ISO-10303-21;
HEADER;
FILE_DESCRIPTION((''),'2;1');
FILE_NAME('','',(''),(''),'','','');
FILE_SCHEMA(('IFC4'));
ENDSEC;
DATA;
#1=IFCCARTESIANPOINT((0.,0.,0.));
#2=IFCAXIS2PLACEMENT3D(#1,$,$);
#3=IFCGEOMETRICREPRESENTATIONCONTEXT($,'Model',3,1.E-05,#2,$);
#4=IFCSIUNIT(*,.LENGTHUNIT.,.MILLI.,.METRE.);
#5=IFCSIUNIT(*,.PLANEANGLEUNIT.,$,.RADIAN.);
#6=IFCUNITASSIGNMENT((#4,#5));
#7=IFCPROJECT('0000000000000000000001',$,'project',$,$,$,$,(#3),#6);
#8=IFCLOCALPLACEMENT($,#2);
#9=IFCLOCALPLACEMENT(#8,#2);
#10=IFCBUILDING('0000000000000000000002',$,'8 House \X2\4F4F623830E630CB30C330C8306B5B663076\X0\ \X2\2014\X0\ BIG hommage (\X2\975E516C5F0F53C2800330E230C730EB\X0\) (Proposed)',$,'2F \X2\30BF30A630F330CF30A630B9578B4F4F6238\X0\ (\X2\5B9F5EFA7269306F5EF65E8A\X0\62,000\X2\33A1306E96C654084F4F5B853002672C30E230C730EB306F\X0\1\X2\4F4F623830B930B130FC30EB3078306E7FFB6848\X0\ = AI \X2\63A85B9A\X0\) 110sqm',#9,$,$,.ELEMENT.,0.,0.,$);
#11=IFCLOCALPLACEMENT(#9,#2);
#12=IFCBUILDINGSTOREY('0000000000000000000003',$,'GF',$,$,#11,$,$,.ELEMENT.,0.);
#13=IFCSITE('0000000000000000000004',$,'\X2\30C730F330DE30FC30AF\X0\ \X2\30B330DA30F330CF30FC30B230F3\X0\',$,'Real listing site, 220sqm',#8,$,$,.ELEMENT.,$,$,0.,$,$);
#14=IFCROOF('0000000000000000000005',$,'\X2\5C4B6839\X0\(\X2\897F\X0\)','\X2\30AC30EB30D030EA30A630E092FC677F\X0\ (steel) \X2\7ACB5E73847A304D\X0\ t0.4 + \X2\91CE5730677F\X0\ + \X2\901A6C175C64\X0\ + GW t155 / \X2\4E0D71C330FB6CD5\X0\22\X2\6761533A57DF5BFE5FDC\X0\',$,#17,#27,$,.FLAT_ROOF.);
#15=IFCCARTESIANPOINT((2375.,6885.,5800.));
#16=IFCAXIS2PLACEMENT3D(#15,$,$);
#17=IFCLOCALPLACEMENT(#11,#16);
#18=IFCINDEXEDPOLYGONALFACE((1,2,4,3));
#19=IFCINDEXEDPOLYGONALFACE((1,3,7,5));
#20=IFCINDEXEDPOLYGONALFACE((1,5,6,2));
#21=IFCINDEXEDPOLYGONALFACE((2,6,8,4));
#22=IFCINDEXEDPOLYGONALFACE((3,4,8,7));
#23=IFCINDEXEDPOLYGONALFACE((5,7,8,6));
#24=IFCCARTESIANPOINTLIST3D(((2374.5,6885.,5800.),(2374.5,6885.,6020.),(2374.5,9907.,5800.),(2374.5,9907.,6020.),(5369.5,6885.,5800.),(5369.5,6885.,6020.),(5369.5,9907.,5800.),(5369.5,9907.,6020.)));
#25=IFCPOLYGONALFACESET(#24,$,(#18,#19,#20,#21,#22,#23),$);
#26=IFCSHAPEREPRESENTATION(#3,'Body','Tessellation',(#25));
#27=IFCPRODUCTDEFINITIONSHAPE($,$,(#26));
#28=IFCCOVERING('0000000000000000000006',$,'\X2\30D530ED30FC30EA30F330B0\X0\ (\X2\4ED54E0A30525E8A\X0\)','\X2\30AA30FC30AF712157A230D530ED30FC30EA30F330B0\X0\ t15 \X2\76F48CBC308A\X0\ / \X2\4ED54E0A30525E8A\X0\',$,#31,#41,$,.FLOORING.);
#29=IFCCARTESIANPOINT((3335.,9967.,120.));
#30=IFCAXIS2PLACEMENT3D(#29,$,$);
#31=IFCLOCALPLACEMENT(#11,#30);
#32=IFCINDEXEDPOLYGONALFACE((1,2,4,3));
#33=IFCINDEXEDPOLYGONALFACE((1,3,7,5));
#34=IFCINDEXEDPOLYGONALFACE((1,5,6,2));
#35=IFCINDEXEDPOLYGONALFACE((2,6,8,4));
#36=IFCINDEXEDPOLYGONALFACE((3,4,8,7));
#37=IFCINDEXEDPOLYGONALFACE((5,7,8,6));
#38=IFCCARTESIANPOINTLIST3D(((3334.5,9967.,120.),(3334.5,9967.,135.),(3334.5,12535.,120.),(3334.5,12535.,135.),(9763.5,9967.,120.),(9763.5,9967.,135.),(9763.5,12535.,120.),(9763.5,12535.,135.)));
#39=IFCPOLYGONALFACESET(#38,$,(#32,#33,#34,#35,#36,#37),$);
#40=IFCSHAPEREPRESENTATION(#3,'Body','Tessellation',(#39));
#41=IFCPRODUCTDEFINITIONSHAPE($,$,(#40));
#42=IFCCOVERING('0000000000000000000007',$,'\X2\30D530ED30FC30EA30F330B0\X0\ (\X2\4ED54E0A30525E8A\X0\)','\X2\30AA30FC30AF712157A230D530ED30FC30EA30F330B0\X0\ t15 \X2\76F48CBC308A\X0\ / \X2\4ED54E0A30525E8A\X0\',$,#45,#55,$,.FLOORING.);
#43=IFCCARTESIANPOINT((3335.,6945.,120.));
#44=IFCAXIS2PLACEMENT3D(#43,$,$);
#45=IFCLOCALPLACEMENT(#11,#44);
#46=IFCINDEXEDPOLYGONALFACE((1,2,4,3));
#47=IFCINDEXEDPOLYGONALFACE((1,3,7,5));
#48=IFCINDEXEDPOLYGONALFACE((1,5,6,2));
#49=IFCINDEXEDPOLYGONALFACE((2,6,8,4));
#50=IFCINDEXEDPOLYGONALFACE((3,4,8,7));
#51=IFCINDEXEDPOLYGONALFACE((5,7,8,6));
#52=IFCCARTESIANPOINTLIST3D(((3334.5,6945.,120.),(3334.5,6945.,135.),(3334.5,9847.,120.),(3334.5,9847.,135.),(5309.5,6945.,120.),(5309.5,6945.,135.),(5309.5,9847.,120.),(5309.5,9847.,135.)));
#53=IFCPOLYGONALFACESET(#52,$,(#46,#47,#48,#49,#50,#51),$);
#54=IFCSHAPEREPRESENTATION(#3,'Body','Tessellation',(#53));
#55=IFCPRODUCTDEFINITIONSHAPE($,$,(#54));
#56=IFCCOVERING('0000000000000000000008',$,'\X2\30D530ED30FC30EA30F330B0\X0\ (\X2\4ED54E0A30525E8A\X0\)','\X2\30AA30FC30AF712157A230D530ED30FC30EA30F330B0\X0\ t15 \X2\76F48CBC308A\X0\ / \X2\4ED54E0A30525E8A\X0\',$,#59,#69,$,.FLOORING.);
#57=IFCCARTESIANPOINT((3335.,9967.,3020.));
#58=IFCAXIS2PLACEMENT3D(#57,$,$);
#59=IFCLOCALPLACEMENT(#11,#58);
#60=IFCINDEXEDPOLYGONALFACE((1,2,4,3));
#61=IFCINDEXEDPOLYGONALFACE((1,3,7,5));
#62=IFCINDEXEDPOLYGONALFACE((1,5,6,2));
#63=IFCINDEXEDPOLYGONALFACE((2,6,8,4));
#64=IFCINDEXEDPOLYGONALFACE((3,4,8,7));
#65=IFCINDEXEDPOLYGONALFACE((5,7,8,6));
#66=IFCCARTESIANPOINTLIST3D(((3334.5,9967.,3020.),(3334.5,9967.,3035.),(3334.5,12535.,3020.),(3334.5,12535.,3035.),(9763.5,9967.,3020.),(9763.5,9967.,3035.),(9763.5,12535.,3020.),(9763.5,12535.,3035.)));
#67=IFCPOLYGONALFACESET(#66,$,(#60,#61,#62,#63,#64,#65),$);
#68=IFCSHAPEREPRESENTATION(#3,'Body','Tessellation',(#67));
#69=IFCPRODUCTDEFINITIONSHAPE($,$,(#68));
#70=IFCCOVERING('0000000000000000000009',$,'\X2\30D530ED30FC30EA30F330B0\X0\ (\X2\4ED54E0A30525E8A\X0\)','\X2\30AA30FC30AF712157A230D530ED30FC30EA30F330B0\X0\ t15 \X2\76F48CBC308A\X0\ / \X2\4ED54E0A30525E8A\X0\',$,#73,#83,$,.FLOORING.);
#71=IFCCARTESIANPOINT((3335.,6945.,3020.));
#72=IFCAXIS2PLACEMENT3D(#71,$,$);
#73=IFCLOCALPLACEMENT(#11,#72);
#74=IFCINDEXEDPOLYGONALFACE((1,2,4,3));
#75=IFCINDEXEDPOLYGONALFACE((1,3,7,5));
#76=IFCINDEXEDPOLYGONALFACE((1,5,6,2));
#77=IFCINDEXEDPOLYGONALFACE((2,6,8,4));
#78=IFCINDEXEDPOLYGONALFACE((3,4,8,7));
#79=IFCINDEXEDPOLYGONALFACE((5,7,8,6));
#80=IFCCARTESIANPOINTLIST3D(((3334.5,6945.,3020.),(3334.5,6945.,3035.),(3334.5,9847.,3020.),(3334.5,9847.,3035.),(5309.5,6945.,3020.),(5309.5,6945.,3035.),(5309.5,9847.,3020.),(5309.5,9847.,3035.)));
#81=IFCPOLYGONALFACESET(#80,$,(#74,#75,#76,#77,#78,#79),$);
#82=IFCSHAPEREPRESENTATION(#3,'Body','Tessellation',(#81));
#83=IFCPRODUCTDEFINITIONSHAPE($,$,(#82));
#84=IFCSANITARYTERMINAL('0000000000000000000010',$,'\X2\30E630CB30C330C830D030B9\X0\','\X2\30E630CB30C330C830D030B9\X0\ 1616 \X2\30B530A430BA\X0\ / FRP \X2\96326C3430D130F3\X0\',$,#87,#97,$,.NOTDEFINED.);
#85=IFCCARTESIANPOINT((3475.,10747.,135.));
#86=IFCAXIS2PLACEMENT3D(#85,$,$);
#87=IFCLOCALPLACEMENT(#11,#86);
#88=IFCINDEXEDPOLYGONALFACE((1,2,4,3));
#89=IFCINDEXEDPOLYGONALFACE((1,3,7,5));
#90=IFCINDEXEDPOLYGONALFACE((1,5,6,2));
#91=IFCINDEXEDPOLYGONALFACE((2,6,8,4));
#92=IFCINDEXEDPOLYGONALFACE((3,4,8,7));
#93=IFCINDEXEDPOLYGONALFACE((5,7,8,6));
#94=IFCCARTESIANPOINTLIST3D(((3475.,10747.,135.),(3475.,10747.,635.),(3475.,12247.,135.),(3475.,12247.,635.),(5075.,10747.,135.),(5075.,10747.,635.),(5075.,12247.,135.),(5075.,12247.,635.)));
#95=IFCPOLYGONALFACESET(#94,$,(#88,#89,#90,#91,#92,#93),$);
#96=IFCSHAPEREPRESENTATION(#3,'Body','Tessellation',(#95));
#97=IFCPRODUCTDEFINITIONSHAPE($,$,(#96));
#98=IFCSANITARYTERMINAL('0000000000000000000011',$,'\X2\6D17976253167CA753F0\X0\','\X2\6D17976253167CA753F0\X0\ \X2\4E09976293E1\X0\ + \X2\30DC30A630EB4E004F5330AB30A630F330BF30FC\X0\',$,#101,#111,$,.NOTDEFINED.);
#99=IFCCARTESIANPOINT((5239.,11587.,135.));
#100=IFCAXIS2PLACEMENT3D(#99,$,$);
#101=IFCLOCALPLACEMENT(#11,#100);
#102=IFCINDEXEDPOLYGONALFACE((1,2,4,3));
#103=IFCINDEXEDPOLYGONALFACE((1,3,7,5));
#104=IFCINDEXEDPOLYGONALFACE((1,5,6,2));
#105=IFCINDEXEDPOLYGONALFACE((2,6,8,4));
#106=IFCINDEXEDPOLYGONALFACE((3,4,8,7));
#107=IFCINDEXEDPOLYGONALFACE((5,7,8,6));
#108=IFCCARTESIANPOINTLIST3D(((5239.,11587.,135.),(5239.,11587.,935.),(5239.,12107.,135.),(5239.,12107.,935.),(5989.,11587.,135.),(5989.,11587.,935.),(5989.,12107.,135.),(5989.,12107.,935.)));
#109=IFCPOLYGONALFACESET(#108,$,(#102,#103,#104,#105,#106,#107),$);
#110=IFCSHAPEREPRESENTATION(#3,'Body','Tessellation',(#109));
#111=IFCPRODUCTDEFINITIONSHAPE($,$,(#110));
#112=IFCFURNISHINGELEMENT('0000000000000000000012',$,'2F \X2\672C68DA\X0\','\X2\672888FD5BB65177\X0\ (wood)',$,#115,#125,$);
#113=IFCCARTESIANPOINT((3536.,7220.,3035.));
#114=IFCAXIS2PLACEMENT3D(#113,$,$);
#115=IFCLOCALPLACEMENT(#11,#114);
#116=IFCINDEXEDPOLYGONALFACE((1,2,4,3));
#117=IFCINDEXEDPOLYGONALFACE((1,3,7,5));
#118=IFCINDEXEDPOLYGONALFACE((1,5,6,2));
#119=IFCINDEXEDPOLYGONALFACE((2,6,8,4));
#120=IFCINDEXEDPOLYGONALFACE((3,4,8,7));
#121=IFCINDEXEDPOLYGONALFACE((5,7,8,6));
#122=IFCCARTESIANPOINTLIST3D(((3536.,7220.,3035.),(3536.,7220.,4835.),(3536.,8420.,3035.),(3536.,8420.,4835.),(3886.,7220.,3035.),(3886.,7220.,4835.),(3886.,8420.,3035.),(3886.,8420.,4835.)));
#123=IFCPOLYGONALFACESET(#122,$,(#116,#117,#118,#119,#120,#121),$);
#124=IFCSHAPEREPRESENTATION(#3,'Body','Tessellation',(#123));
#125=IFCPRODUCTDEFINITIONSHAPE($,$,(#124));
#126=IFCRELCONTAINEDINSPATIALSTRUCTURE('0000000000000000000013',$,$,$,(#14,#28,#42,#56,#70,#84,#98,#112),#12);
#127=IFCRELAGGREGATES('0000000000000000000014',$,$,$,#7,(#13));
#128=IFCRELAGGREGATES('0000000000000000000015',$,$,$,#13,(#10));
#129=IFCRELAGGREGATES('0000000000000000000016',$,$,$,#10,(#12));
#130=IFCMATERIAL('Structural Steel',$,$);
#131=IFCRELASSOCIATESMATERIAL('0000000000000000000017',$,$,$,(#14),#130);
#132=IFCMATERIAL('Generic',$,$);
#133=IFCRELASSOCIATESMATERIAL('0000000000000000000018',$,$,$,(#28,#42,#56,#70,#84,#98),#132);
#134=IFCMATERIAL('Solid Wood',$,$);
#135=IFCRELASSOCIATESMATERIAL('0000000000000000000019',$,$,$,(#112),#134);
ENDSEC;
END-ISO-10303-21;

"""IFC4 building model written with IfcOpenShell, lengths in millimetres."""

from ifc_helpers import new_model, si_unit, frame, frame_2d, origin, place, context, project, spatial, rectangle, extrude, material, element, save


model = new_model("IFC4")

# Units and contexts
model_context = context("Model", 3, precision=1e-05, world=origin())
ifc_project = project(units=[si_unit("LENGTHUNIT", "METRE", prefix="MILLI"), si_unit("PLANEANGLEUNIT", "RADIAN")], contexts=[model_context])

# Site, building, storey
site_placement = place(None, origin())
site = spatial("IfcSite", under=ifc_project, at=site_placement, Name="デンマーク コペンハーゲン", ObjectType="Real listing site, 220sqm", CompositionType="ELEMENT", RefElevation=0.0)
building_placement = place(site_placement, origin())
building = spatial("IfcBuilding", under=site, at=building_placement, Name="8 House 住戸ユニットに学ぶ — BIG hommage (非公式参考モデル) (Proposed)", ObjectType="2F タウンハウス型住戸 (実建物は延床62,000㎡の集合住宅。本モデルは1住戸スケールへの翻案 = AI 推定) 110sqm", CompositionType="ELEMENT", ElevationOfRefHeight=0.0, ElevationOfTerrain=0.0)
storey_placement = place(building_placement, origin())
storey = spatial("IfcBuildingStorey", under=building, at=storey_placement, Name="GF", CompositionType="ELEMENT", Elevation=0.0)

# Shared definitions
ifc_material_1 = material(Name="Solid Wood")

# Roof
ifc_material_2 = material(Name="Structural Steel")
roof_placement = place(storey_placement, frame((2375.0, 6885.0, 5800.0)))
element("IfcRoof", 1, at=roof_placement, inside=storey, material=ifc_material_2, Name="屋根(西)", Description="ガルバリウム鋼板 (steel) 立平葺き t0.4 + 野地板 + 通気層 + GW t155 / 不燃・法22条区域対応", PredefinedType="FLAT_ROOF", context=model_context, shape_type="SweptSolid", body=[
    extrude(rectangle(XDim=2995.0, YDim=3022.0, at=frame_2d((1497.0, 1511.0))), frame((2375.0, 6885.0, 5800.0)), (0.0, 0.0, 1.0), 220.0),
])

# Coverings
ifc_material_3 = material(Name="Generic")
covering_1_placement = place(storey_placement, frame((3335.0, 9967.0, 120.0)))
element("IfcCovering", 2, at=covering_1_placement, inside=storey, material=ifc_material_3, Name="フローリング (仕上げ床)", Description="オーク無垢フローリング t15 直貼り / 仕上げ床", PredefinedType="FLOORING", context=model_context, shape_type="SweptSolid", body=[
    extrude(rectangle(XDim=6429.0, YDim=2568.0, at=frame_2d((3214.0, 1284.0))), frame((3335.0, 9967.0, 120.0)), (0.0, 0.0, 1.0), 15.0),
])
covering_2_placement = place(storey_placement, frame((3335.0, 6945.0, 120.0)))
element("IfcCovering", 3, at=covering_2_placement, inside=storey, material=ifc_material_3, Name="フローリング (仕上げ床)", Description="オーク無垢フローリング t15 直貼り / 仕上げ床", PredefinedType="FLOORING", context=model_context, shape_type="SweptSolid", body=[
    extrude(rectangle(XDim=1975.0, YDim=2902.0, at=frame_2d((987.0, 1451.0))), frame((3335.0, 6945.0, 120.0)), (0.0, 0.0, 1.0), 15.0),
])
covering_3_placement = place(storey_placement, frame((3335.0, 9967.0, 3020.0)))
element("IfcCovering", 4, at=covering_3_placement, inside=storey, material=ifc_material_3, Name="フローリング (仕上げ床)", Description="オーク無垢フローリング t15 直貼り / 仕上げ床", PredefinedType="FLOORING", context=model_context, shape_type="SweptSolid", body=[
    extrude(rectangle(XDim=6429.0, YDim=2568.0, at=frame_2d((3214.0, 1284.0))), frame((3335.0, 9967.0, 3020.0)), (0.0, 0.0, 1.0), 15.0),
])
covering_4_placement = place(storey_placement, frame((3335.0, 6945.0, 3020.0)))
element("IfcCovering", 5, at=covering_4_placement, inside=storey, material=ifc_material_3, Name="フローリング (仕上げ床)", Description="オーク無垢フローリング t15 直貼り / 仕上げ床", PredefinedType="FLOORING", context=model_context, shape_type="SweptSolid", body=[
    extrude(rectangle(XDim=1975.0, YDim=2902.0, at=frame_2d((987.0, 1451.0))), frame((3335.0, 6945.0, 3020.0)), (0.0, 0.0, 1.0), 15.0),
])

# Sanitary terminals
sanitary_terminal_1_placement = place(storey_placement, frame((3475.0, 10747.0, 135.0)))
element("IfcSanitaryTerminal", 6, at=sanitary_terminal_1_placement, inside=storey, material=ifc_material_3, Name="ユニットバス", Description="ユニットバス 1616 サイズ / FRP 防水パン", PredefinedType="NOTDEFINED", context=model_context, shape_type="SweptSolid", body=[
    extrude(rectangle(XDim=1600.0, YDim=1500.0, at=frame_2d((800.0, 750.0))), frame((3475.0, 10747.0, 135.0)), (0.0, 0.0, 1.0), 500.0),
])
sanitary_terminal_2_placement = place(storey_placement, frame((5239.0, 11587.0, 135.0)))
element("IfcSanitaryTerminal", 7, at=sanitary_terminal_2_placement, inside=storey, material=ifc_material_3, Name="洗面化粧台", Description="洗面化粧台 三面鏡 + ボウル一体カウンター", PredefinedType="NOTDEFINED", context=model_context, shape_type="SweptSolid", body=[
    extrude(rectangle(XDim=750.0, YDim=520.0, at=frame_2d((375.0, 260.0))), frame((5239.0, 11587.0, 135.0)), (0.0, 0.0, 1.0), 800.0),
])

# Furnishing element
furnishing_placement = place(storey_placement, frame((3536.0, 7220.0, 3035.0)))
element("IfcFurnishingElement", 8, at=furnishing_placement, inside=storey, material=ifc_material_1, Name="2F 本棚", Description="木製家具 (wood)", context=model_context, shape_type="SweptSolid", body=[
    extrude(rectangle(XDim=350.0, YDim=1200.0, at=frame_2d((175.0, 600.0))), frame((3536.0, 7220.0, 3035.0)), (0.0, 0.0, 1.0), 1800.0),
])

save(model, "model.ifc")
